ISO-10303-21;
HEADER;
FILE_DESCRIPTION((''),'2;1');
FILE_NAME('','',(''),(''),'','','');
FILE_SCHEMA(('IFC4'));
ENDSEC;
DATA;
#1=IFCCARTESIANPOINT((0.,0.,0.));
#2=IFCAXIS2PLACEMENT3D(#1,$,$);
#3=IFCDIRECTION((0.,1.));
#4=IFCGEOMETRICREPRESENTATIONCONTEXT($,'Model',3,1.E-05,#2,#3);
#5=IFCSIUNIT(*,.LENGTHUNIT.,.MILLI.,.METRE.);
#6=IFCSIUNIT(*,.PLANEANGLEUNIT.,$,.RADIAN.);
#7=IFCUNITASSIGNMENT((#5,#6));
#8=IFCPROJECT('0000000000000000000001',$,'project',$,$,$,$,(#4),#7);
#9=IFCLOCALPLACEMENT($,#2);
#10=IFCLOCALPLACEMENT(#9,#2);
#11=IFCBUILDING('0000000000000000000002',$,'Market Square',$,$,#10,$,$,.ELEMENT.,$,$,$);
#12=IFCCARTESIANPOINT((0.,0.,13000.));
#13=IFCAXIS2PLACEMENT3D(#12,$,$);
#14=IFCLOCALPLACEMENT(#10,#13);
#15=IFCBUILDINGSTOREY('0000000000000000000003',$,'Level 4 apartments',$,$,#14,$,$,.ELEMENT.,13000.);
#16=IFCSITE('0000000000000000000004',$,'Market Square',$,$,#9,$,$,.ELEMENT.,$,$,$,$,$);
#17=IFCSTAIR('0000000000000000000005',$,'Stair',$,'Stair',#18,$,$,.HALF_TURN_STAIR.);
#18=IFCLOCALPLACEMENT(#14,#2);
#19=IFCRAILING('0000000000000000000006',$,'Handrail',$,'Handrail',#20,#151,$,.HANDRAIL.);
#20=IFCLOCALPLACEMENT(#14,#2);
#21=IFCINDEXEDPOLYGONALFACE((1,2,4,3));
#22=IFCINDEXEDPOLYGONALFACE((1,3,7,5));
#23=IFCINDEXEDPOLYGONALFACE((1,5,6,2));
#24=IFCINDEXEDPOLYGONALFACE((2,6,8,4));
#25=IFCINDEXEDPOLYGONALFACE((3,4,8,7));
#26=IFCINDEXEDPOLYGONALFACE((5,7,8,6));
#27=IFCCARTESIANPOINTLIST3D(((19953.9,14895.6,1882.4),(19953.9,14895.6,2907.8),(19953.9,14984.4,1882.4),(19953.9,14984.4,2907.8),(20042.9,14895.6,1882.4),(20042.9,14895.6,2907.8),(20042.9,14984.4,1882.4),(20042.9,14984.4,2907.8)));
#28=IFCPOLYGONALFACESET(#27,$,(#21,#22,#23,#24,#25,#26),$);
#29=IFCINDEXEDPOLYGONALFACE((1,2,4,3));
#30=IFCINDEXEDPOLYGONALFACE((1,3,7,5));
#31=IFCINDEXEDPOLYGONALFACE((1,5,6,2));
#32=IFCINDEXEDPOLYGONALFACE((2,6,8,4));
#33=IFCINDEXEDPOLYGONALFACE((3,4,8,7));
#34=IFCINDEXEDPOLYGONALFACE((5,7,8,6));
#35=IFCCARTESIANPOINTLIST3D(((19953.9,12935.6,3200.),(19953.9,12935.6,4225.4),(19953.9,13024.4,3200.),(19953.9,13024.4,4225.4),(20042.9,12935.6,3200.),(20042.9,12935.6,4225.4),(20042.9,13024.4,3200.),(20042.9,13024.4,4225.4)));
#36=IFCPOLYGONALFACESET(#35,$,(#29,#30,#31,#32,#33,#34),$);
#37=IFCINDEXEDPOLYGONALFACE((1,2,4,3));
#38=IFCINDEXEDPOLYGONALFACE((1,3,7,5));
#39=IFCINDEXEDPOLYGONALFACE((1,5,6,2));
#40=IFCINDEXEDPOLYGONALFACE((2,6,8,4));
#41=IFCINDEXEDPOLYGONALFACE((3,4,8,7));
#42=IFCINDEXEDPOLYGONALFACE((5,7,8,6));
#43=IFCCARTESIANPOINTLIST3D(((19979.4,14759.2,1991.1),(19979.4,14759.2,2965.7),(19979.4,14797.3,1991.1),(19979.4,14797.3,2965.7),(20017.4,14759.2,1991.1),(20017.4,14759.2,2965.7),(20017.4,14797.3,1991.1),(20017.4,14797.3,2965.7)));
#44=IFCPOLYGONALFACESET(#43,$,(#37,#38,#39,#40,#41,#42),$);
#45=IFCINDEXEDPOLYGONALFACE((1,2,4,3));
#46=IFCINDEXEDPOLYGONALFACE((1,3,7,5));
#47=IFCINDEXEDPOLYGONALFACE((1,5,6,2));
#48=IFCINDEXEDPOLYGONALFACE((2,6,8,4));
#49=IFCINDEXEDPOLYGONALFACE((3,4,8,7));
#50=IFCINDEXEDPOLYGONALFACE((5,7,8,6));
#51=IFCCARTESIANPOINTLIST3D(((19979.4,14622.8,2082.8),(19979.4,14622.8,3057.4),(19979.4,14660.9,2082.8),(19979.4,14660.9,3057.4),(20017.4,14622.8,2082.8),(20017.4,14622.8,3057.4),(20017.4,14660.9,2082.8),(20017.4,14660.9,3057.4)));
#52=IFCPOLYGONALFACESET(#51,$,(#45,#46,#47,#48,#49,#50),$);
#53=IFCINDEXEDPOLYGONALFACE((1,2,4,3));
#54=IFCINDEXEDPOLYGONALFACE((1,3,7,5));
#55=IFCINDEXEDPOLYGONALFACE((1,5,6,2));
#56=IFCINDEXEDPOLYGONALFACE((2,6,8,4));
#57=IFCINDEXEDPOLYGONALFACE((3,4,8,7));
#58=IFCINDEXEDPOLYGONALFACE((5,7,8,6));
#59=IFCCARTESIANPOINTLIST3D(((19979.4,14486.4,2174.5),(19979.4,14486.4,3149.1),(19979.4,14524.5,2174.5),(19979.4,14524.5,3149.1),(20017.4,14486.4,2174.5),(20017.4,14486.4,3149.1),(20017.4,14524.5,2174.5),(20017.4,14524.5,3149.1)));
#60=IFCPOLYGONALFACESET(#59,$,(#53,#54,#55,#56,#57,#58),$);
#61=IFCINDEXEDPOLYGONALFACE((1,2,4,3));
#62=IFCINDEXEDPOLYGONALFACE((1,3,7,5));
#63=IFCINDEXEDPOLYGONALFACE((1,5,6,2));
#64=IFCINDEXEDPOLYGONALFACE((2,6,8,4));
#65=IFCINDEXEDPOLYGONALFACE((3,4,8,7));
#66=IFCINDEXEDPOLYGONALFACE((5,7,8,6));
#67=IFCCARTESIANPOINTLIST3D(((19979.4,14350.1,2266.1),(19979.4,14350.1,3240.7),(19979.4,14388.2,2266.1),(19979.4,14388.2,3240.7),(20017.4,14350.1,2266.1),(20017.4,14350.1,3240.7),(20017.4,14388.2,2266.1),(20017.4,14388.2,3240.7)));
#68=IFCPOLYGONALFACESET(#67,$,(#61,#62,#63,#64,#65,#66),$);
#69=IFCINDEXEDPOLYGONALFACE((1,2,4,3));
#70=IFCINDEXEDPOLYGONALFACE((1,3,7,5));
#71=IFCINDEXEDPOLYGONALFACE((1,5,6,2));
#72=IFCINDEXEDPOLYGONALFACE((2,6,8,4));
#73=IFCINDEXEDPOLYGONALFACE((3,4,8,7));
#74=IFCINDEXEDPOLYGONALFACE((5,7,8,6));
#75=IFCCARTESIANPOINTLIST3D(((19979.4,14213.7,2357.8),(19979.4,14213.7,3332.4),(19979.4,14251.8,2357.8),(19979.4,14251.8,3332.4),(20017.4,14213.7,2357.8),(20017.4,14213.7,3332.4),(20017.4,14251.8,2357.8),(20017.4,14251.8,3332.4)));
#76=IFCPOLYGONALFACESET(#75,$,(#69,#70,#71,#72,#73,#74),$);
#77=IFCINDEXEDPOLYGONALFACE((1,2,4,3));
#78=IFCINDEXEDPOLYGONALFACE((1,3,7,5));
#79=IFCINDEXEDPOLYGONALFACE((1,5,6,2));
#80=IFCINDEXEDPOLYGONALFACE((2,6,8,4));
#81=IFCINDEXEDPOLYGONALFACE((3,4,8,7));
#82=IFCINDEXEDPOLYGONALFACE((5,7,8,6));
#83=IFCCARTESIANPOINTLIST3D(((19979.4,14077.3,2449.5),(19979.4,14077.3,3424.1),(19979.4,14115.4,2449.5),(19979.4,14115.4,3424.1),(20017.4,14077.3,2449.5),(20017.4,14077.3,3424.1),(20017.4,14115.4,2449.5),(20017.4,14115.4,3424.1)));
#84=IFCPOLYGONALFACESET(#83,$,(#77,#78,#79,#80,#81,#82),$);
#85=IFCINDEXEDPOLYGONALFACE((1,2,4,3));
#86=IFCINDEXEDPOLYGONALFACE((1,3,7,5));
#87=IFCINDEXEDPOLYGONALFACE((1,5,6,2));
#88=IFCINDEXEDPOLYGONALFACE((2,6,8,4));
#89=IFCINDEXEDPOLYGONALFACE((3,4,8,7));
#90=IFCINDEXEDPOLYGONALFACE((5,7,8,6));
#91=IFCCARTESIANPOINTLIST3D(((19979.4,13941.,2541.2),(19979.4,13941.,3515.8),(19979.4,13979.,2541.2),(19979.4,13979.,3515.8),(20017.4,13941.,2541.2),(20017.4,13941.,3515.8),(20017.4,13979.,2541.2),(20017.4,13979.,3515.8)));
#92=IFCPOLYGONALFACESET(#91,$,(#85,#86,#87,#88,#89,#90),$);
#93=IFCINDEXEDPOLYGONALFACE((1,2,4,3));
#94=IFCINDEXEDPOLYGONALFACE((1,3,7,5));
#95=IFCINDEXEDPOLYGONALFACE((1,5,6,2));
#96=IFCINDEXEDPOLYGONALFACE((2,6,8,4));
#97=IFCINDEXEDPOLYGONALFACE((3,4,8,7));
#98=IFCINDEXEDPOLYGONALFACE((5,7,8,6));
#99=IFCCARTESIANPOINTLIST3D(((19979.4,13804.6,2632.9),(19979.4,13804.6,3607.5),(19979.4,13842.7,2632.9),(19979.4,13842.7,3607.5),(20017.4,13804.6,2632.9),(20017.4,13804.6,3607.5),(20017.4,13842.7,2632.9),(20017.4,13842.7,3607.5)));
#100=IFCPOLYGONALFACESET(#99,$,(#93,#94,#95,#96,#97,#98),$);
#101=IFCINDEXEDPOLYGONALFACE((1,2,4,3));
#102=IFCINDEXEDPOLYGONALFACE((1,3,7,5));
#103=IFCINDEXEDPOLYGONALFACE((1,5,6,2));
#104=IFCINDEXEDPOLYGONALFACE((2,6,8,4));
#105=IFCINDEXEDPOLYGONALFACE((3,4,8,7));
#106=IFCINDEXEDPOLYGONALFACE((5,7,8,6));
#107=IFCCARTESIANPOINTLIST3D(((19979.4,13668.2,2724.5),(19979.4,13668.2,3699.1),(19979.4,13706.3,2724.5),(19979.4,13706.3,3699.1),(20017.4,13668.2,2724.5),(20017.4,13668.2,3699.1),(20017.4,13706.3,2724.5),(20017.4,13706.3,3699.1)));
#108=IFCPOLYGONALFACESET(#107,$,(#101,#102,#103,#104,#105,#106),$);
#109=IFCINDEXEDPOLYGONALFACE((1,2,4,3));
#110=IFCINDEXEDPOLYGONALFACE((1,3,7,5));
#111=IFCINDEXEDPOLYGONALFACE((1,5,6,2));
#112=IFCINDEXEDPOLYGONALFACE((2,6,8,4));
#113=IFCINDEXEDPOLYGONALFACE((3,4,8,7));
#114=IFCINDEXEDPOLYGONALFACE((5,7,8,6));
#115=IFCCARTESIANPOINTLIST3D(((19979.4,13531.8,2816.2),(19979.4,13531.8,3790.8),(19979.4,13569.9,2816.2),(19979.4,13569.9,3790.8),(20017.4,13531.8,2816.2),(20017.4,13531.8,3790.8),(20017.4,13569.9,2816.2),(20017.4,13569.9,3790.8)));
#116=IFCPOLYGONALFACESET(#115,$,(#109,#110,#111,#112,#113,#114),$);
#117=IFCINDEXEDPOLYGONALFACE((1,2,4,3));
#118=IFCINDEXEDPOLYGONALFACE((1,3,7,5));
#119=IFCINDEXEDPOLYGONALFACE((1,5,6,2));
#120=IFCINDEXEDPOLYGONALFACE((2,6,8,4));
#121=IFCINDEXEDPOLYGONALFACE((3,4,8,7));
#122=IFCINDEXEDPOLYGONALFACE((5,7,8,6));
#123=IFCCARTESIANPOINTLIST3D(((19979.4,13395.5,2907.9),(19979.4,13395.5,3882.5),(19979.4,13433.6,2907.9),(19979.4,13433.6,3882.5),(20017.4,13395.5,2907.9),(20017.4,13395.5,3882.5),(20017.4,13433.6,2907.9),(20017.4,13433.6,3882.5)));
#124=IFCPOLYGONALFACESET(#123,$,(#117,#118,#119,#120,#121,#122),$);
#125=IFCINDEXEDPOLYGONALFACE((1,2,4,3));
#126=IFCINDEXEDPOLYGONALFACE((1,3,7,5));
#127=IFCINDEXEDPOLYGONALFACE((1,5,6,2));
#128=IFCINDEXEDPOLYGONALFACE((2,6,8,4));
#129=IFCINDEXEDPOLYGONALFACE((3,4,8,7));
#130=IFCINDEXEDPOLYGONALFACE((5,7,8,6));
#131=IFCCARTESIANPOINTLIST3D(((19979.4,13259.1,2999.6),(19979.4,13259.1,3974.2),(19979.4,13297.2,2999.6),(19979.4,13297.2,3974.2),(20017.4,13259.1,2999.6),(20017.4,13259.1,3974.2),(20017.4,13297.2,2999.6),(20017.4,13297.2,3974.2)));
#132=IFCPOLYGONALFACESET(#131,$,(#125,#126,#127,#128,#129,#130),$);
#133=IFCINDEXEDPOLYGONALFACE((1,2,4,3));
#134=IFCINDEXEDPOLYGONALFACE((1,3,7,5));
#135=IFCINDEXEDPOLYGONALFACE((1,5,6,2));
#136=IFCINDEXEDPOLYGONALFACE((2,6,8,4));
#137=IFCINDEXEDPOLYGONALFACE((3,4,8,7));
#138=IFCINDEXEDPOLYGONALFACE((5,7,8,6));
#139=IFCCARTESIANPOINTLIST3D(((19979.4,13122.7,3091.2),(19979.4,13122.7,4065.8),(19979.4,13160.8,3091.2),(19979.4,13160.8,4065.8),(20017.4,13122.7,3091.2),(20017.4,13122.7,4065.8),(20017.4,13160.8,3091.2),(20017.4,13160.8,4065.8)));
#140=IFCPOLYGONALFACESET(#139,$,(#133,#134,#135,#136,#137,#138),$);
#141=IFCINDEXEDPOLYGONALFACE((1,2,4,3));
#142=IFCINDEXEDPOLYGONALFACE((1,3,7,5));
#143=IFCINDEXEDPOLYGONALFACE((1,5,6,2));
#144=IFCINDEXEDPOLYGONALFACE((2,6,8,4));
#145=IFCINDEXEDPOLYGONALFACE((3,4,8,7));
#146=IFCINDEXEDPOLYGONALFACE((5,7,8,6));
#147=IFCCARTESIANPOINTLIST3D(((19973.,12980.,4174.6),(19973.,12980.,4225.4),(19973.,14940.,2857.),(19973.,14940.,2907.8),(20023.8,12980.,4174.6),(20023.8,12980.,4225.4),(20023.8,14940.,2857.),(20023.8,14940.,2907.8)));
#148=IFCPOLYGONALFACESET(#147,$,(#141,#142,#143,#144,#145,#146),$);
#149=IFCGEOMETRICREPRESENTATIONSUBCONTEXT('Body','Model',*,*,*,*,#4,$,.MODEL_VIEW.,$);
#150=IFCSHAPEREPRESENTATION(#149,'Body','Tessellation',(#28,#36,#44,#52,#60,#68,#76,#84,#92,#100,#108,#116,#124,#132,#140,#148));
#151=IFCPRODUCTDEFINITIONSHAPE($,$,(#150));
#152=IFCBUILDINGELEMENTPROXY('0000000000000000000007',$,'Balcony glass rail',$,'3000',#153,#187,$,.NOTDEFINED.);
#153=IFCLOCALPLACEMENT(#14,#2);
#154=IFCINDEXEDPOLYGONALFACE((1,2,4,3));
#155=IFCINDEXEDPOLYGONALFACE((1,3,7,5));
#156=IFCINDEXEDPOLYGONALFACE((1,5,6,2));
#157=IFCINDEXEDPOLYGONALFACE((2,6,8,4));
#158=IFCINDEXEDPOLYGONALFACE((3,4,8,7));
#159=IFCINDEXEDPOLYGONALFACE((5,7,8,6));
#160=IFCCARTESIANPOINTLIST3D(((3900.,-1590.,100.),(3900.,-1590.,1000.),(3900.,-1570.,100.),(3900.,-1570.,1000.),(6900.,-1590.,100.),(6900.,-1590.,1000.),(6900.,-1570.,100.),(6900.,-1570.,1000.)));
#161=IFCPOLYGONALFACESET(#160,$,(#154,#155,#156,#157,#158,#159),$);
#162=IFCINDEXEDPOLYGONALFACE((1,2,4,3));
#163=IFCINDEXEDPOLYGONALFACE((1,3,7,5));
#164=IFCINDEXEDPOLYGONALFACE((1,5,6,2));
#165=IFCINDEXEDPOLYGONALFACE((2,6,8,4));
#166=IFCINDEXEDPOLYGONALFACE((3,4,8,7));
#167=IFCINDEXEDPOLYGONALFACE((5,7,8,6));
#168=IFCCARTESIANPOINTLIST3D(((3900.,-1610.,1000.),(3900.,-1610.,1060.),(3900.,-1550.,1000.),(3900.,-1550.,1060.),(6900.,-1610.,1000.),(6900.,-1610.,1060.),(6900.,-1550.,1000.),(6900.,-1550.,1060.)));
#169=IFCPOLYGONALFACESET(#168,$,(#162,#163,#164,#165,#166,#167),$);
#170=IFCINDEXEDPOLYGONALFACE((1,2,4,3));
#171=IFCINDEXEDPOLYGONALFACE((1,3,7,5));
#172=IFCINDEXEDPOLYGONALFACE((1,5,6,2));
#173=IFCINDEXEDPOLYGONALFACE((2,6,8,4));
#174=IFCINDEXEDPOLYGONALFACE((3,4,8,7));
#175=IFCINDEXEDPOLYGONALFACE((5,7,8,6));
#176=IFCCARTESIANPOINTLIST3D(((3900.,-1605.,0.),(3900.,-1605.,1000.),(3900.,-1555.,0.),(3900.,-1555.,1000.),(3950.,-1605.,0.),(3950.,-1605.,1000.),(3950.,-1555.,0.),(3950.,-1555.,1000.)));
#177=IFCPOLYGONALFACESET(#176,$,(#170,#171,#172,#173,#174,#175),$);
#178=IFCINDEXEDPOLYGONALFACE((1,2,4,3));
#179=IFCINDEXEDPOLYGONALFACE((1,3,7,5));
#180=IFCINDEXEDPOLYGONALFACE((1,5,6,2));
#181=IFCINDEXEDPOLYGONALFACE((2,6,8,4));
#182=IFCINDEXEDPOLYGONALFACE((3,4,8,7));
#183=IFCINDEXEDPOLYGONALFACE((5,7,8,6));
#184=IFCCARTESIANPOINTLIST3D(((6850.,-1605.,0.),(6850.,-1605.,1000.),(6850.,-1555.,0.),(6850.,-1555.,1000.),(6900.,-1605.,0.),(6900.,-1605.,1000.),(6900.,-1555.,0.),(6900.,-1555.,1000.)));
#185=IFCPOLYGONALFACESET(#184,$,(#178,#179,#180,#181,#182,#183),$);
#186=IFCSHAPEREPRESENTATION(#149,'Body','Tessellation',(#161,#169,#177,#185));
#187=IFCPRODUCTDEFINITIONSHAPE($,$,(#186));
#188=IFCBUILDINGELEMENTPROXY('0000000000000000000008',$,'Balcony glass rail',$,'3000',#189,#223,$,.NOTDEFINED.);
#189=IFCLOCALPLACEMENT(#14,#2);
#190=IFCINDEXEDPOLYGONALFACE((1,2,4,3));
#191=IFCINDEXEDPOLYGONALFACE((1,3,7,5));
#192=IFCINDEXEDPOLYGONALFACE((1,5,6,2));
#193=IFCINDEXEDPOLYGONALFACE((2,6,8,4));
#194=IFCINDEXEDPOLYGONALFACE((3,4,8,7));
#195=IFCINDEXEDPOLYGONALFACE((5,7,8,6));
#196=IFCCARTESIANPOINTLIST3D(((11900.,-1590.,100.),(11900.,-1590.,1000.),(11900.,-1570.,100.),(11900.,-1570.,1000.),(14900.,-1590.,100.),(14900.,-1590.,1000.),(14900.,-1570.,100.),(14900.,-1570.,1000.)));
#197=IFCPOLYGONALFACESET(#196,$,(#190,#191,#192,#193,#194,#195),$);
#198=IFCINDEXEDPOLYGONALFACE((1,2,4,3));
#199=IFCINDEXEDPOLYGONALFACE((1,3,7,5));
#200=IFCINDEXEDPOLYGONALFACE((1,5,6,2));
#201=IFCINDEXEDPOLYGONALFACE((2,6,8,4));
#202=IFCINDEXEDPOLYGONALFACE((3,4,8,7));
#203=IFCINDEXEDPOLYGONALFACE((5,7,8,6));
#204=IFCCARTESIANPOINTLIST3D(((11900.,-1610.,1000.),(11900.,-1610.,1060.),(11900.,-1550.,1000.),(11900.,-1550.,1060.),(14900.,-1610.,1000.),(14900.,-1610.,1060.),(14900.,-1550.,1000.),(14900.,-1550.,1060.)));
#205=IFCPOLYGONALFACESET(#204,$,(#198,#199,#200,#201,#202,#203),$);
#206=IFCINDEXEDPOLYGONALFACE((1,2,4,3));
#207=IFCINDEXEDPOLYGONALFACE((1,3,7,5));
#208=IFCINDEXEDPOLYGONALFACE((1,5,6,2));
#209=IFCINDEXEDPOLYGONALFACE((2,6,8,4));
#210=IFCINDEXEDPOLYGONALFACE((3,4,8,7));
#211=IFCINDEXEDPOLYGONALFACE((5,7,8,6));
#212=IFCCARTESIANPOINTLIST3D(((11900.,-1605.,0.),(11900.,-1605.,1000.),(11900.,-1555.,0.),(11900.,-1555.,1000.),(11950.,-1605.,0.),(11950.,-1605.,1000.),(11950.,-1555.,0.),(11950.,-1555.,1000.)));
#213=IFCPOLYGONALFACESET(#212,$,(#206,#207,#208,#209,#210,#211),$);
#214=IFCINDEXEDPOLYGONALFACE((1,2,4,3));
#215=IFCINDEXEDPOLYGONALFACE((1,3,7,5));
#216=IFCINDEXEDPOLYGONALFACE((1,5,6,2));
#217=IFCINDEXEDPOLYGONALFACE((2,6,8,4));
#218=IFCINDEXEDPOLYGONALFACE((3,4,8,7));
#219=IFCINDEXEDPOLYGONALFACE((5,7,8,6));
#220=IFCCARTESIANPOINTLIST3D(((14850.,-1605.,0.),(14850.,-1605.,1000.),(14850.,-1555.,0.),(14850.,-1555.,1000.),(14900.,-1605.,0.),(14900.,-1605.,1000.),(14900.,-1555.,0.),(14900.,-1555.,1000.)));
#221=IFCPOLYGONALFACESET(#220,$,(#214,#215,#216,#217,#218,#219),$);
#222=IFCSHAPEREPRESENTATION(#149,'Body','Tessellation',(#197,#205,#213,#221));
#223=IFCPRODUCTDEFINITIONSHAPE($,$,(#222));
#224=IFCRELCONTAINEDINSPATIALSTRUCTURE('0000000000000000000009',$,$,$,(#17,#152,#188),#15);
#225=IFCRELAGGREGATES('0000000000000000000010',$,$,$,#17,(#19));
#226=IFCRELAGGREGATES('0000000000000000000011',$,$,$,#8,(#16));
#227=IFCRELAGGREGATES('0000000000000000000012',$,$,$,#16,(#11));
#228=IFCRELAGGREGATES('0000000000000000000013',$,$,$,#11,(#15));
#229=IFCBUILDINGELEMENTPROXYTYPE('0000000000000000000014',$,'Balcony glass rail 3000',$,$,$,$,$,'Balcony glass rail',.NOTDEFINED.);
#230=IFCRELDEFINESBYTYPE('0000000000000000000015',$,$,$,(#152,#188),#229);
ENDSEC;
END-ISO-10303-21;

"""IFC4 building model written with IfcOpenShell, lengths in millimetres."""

from ifc_helpers import new_model, si_unit, direction, frame, origin, origin_with_axes, place, context, subcontext, project, spatial, polyline, outline, extrude, source, transform, mapped, type_object, type_shapes, element, aggregate, save


model = new_model("IFC4")

# Units and contexts
model_context = context("Model", 3, precision=1e-05, world=origin(), true_north=direction((0.0, 1.0)))
body_context = subcontext(model_context, "Body", "Model", "MODEL_VIEW")
ifc_project = project(units=[si_unit("LENGTHUNIT", "METRE", prefix="MILLI"), si_unit("PLANEANGLEUNIT", "RADIAN")], contexts=[model_context])

# Site, building, storey
site_placement = place(None, origin())
site = spatial("IfcSite", under=ifc_project, at=site_placement, Name="Market Square", CompositionType="ELEMENT")
building_placement = place(site_placement, origin())
building = spatial("IfcBuilding", under=site, at=building_placement, Name="Market Square", CompositionType="ELEMENT")
storey_placement = place(building_placement, frame((0.0, 0.0, 13000.0)))
storey = spatial("IfcBuildingStorey", under=building, at=storey_placement, Name="Level 4 apartments", CompositionType="ELEMENT", Elevation=13000.0)

# Stair
stair_placement = place(storey_placement, origin_with_axes())
stair = element("IfcStair", 1, at=stair_placement, inside=storey, Name="Stair", ObjectType="Stair", PredefinedType="HALF_TURN_STAIR")

# Railing
railing_1_placement = place(storey_placement, origin_with_axes())
railing_1 = element("IfcRailing", 2, at=railing_1_placement, Name="Handrail", ObjectType="Handrail", PredefinedType="HANDRAIL", context=body_context, shape_type="SweptSolid", body=[
    extrude(outline(polyline([(-44.5, -44.5), (44.5, -44.5), (44.5, 44.5), (-44.5, 44.5), (-44.5, -44.5)])), frame((19998.4, 14940.0, 1882.4), z_axis=(0.0, 0.0, 1.0), x_axis=(1.0, 0.0, 0.0)), (0.0, 0.0, 1.0), 1025.4),
    extrude(outline(polyline([(-44.5, -44.5), (44.5, -44.5), (44.5, 44.5), (-44.5, 44.5), (-44.5, -44.5)])), frame((19998.4, 12980.0, 3200.0), z_axis=(0.0, 0.0, 1.0), x_axis=(1.0, 0.0, 0.0)), (0.0, 0.0, 1.0), 1025.4),
    extrude(outline(polyline([(-19.1, -19.1), (19.1, -19.1), (19.1, 19.1), (-19.1, 19.1), (-19.1, -19.1)])), frame((19998.4, 14778.2, 1991.1), z_axis=(0.0, 0.0, 1.0), x_axis=(1.0, 0.0, 0.0)), (0.0, 0.0, 1.0), 974.6),
    extrude(outline(polyline([(-19.1, -19.1), (19.1, -19.1), (19.1, 19.1), (-19.1, 19.1), (-19.1, -19.1)])), frame((19998.4, 14641.9, 2082.8), z_axis=(0.0, 0.0, 1.0), x_axis=(1.0, 0.0, 0.0)), (0.0, 0.0, 1.0), 974.6),
    extrude(outline(polyline([(-19.1, -19.1), (19.1, -19.1), (19.1, 19.1), (-19.1, 19.1), (-19.1, -19.1)])), frame((19998.4, 14505.5, 2174.5), z_axis=(0.0, 0.0, 1.0), x_axis=(1.0, 0.0, 0.0)), (0.0, 0.0, 1.0), 974.6),
    extrude(outline(polyline([(-19.1, -19.1), (19.1, -19.1), (19.1, 19.1), (-19.1, 19.1), (-19.1, -19.1)])), frame((19998.4, 14369.1, 2266.1), z_axis=(0.0, 0.0, 1.0), x_axis=(1.0, 0.0, 0.0)), (0.0, 0.0, 1.0), 974.6),
    extrude(outline(polyline([(-19.1, -19.1), (19.1, -19.1), (19.1, 19.1), (-19.1, 19.1), (-19.1, -19.1)])), frame((19998.4, 14232.7, 2357.8), z_axis=(0.0, 0.0, 1.0), x_axis=(1.0, 0.0, 0.0)), (0.0, 0.0, 1.0), 974.6),
    extrude(outline(polyline([(-19.1, -19.1), (19.1, -19.1), (19.1, 19.1), (-19.1, 19.1), (-19.1, -19.1)])), frame((19998.4, 14096.4, 2449.5), z_axis=(0.0, 0.0, 1.0), x_axis=(1.0, 0.0, 0.0)), (0.0, 0.0, 1.0), 974.6),
    extrude(outline(polyline([(-19.1, -19.1), (19.1, -19.1), (19.1, 19.1), (-19.1, 19.1), (-19.1, -19.1)])), frame((19998.4, 13960.0, 2541.2), z_axis=(0.0, 0.0, 1.0), x_axis=(1.0, 0.0, 0.0)), (0.0, 0.0, 1.0), 974.6),
    extrude(outline(polyline([(-19.1, -19.1), (19.1, -19.1), (19.1, 19.1), (-19.1, 19.1), (-19.1, -19.1)])), frame((19998.4, 13823.6, 2632.9), z_axis=(0.0, 0.0, 1.0), x_axis=(1.0, 0.0, 0.0)), (0.0, 0.0, 1.0), 974.6),
    extrude(outline(polyline([(-19.1, -19.1), (19.1, -19.1), (19.1, 19.1), (-19.1, 19.1), (-19.1, -19.1)])), frame((19998.4, 13687.3, 2724.5), z_axis=(0.0, 0.0, 1.0), x_axis=(1.0, 0.0, 0.0)), (0.0, 0.0, 1.0), 974.6),
    extrude(outline(polyline([(-19.1, -19.1), (19.1, -19.1), (19.1, 19.1), (-19.1, 19.1), (-19.1, -19.1)])), frame((19998.4, 13550.9, 2816.2), z_axis=(0.0, 0.0, 1.0), x_axis=(1.0, 0.0, 0.0)), (0.0, 0.0, 1.0), 974.6),
    extrude(outline(polyline([(-19.1, -19.1), (19.1, -19.1), (19.1, 19.1), (-19.1, 19.1), (-19.1, -19.1)])), frame((19998.4, 13414.5, 2907.9), z_axis=(0.0, 0.0, 1.0), x_axis=(1.0, 0.0, 0.0)), (0.0, 0.0, 1.0), 974.6),
    extrude(outline(polyline([(-19.1, -19.1), (19.1, -19.1), (19.1, 19.1), (-19.1, 19.1), (-19.1, -19.1)])), frame((19998.4, 13278.1, 2999.6), z_axis=(0.0, 0.0, 1.0), x_axis=(1.0, 0.0, 0.0)), (0.0, 0.0, 1.0), 974.6),
    extrude(outline(polyline([(-19.1, -19.1), (19.1, -19.1), (19.1, 19.1), (-19.1, 19.1), (-19.1, -19.1)])), frame((19998.4, 13141.8, 3091.2), z_axis=(0.0, 0.0, 1.0), x_axis=(1.0, 0.0, 0.0)), (0.0, 0.0, 1.0), 974.6),
    extrude(outline(polyline([(0.0, 0.0), (50.8, 0.0), (50.8, 50.8), (0.0, 50.8), (0.0, 0.0)])), frame((19973.0, 14940.0, 2857.0), z_axis=(0.0, -1.0, 0.0), x_axis=(1.0, 0.0, 0.0)), (0.0, 0.557915, 0.829898), 2361.7),
])
aggregate(stair, [railing_1])

# Building element proxies
building_element_proxy_type = type_object("IfcBuildingElementProxyType", Name="Balcony glass rail 3000", ElementType="Balcony glass rail", PredefinedType="NOTDEFINED")
shared_shape = source(origin(), body_context, "Body", "SweptSolid", [
    extrude(outline(polyline([(0.0, -10.0), (3000.0, -10.0), (3000.0, 10.0), (0.0, 10.0), (0.0, -10.0)])), frame((0.0, 0.0, 100.0)), (0.0, 0.0, 1.0), 900.0),
    extrude(outline(polyline([(0.0, -30.0), (3000.0, -30.0), (3000.0, 30.0), (0.0, 30.0), (0.0, -30.0)])), frame((0.0, 0.0, 1000.0)), (0.0, 0.0, 1.0), 60.0),
    extrude(outline(polyline([(0.0, -25.0), (50.0, -25.0), (50.0, 25.0), (0.0, 25.0), (0.0, -25.0)])), origin(), (0.0, 0.0, 1.0), 1000.0),
    extrude(outline(polyline([(2950.0, -25.0), (3000.0, -25.0), (3000.0, 25.0), (2950.0, 25.0), (2950.0, -25.0)])), origin(), (0.0, 0.0, 1.0), 1000.0),
])
type_shapes(building_element_proxy_type, [shared_shape])
for number, where, z_axis, x_axis, name in (
    (3, (3900.0, -1580.0, 0.0), (0.0, 0.0, 1.0), (1.0, 0.0, 0.0), "Balcony glass rail"),
    (4, (11900.0, -1580.0, 0.0), (0.0, 0.0, 1.0), (1.0, 0.0, 0.0), "Balcony glass rail"),
):
    element("IfcBuildingElementProxy", number, at=place(storey_placement, frame(where, z_axis=z_axis, x_axis=x_axis)), inside=storey, type_object=building_element_proxy_type, Name=name, ObjectType="3000", PredefinedType="NOTDEFINED", context=body_context, shape_type="MappedRepresentation", body=[
        mapped(shared_shape, transform((0.0, 0.0, 0.0))),
    ])

save(model, "model.ifc")
